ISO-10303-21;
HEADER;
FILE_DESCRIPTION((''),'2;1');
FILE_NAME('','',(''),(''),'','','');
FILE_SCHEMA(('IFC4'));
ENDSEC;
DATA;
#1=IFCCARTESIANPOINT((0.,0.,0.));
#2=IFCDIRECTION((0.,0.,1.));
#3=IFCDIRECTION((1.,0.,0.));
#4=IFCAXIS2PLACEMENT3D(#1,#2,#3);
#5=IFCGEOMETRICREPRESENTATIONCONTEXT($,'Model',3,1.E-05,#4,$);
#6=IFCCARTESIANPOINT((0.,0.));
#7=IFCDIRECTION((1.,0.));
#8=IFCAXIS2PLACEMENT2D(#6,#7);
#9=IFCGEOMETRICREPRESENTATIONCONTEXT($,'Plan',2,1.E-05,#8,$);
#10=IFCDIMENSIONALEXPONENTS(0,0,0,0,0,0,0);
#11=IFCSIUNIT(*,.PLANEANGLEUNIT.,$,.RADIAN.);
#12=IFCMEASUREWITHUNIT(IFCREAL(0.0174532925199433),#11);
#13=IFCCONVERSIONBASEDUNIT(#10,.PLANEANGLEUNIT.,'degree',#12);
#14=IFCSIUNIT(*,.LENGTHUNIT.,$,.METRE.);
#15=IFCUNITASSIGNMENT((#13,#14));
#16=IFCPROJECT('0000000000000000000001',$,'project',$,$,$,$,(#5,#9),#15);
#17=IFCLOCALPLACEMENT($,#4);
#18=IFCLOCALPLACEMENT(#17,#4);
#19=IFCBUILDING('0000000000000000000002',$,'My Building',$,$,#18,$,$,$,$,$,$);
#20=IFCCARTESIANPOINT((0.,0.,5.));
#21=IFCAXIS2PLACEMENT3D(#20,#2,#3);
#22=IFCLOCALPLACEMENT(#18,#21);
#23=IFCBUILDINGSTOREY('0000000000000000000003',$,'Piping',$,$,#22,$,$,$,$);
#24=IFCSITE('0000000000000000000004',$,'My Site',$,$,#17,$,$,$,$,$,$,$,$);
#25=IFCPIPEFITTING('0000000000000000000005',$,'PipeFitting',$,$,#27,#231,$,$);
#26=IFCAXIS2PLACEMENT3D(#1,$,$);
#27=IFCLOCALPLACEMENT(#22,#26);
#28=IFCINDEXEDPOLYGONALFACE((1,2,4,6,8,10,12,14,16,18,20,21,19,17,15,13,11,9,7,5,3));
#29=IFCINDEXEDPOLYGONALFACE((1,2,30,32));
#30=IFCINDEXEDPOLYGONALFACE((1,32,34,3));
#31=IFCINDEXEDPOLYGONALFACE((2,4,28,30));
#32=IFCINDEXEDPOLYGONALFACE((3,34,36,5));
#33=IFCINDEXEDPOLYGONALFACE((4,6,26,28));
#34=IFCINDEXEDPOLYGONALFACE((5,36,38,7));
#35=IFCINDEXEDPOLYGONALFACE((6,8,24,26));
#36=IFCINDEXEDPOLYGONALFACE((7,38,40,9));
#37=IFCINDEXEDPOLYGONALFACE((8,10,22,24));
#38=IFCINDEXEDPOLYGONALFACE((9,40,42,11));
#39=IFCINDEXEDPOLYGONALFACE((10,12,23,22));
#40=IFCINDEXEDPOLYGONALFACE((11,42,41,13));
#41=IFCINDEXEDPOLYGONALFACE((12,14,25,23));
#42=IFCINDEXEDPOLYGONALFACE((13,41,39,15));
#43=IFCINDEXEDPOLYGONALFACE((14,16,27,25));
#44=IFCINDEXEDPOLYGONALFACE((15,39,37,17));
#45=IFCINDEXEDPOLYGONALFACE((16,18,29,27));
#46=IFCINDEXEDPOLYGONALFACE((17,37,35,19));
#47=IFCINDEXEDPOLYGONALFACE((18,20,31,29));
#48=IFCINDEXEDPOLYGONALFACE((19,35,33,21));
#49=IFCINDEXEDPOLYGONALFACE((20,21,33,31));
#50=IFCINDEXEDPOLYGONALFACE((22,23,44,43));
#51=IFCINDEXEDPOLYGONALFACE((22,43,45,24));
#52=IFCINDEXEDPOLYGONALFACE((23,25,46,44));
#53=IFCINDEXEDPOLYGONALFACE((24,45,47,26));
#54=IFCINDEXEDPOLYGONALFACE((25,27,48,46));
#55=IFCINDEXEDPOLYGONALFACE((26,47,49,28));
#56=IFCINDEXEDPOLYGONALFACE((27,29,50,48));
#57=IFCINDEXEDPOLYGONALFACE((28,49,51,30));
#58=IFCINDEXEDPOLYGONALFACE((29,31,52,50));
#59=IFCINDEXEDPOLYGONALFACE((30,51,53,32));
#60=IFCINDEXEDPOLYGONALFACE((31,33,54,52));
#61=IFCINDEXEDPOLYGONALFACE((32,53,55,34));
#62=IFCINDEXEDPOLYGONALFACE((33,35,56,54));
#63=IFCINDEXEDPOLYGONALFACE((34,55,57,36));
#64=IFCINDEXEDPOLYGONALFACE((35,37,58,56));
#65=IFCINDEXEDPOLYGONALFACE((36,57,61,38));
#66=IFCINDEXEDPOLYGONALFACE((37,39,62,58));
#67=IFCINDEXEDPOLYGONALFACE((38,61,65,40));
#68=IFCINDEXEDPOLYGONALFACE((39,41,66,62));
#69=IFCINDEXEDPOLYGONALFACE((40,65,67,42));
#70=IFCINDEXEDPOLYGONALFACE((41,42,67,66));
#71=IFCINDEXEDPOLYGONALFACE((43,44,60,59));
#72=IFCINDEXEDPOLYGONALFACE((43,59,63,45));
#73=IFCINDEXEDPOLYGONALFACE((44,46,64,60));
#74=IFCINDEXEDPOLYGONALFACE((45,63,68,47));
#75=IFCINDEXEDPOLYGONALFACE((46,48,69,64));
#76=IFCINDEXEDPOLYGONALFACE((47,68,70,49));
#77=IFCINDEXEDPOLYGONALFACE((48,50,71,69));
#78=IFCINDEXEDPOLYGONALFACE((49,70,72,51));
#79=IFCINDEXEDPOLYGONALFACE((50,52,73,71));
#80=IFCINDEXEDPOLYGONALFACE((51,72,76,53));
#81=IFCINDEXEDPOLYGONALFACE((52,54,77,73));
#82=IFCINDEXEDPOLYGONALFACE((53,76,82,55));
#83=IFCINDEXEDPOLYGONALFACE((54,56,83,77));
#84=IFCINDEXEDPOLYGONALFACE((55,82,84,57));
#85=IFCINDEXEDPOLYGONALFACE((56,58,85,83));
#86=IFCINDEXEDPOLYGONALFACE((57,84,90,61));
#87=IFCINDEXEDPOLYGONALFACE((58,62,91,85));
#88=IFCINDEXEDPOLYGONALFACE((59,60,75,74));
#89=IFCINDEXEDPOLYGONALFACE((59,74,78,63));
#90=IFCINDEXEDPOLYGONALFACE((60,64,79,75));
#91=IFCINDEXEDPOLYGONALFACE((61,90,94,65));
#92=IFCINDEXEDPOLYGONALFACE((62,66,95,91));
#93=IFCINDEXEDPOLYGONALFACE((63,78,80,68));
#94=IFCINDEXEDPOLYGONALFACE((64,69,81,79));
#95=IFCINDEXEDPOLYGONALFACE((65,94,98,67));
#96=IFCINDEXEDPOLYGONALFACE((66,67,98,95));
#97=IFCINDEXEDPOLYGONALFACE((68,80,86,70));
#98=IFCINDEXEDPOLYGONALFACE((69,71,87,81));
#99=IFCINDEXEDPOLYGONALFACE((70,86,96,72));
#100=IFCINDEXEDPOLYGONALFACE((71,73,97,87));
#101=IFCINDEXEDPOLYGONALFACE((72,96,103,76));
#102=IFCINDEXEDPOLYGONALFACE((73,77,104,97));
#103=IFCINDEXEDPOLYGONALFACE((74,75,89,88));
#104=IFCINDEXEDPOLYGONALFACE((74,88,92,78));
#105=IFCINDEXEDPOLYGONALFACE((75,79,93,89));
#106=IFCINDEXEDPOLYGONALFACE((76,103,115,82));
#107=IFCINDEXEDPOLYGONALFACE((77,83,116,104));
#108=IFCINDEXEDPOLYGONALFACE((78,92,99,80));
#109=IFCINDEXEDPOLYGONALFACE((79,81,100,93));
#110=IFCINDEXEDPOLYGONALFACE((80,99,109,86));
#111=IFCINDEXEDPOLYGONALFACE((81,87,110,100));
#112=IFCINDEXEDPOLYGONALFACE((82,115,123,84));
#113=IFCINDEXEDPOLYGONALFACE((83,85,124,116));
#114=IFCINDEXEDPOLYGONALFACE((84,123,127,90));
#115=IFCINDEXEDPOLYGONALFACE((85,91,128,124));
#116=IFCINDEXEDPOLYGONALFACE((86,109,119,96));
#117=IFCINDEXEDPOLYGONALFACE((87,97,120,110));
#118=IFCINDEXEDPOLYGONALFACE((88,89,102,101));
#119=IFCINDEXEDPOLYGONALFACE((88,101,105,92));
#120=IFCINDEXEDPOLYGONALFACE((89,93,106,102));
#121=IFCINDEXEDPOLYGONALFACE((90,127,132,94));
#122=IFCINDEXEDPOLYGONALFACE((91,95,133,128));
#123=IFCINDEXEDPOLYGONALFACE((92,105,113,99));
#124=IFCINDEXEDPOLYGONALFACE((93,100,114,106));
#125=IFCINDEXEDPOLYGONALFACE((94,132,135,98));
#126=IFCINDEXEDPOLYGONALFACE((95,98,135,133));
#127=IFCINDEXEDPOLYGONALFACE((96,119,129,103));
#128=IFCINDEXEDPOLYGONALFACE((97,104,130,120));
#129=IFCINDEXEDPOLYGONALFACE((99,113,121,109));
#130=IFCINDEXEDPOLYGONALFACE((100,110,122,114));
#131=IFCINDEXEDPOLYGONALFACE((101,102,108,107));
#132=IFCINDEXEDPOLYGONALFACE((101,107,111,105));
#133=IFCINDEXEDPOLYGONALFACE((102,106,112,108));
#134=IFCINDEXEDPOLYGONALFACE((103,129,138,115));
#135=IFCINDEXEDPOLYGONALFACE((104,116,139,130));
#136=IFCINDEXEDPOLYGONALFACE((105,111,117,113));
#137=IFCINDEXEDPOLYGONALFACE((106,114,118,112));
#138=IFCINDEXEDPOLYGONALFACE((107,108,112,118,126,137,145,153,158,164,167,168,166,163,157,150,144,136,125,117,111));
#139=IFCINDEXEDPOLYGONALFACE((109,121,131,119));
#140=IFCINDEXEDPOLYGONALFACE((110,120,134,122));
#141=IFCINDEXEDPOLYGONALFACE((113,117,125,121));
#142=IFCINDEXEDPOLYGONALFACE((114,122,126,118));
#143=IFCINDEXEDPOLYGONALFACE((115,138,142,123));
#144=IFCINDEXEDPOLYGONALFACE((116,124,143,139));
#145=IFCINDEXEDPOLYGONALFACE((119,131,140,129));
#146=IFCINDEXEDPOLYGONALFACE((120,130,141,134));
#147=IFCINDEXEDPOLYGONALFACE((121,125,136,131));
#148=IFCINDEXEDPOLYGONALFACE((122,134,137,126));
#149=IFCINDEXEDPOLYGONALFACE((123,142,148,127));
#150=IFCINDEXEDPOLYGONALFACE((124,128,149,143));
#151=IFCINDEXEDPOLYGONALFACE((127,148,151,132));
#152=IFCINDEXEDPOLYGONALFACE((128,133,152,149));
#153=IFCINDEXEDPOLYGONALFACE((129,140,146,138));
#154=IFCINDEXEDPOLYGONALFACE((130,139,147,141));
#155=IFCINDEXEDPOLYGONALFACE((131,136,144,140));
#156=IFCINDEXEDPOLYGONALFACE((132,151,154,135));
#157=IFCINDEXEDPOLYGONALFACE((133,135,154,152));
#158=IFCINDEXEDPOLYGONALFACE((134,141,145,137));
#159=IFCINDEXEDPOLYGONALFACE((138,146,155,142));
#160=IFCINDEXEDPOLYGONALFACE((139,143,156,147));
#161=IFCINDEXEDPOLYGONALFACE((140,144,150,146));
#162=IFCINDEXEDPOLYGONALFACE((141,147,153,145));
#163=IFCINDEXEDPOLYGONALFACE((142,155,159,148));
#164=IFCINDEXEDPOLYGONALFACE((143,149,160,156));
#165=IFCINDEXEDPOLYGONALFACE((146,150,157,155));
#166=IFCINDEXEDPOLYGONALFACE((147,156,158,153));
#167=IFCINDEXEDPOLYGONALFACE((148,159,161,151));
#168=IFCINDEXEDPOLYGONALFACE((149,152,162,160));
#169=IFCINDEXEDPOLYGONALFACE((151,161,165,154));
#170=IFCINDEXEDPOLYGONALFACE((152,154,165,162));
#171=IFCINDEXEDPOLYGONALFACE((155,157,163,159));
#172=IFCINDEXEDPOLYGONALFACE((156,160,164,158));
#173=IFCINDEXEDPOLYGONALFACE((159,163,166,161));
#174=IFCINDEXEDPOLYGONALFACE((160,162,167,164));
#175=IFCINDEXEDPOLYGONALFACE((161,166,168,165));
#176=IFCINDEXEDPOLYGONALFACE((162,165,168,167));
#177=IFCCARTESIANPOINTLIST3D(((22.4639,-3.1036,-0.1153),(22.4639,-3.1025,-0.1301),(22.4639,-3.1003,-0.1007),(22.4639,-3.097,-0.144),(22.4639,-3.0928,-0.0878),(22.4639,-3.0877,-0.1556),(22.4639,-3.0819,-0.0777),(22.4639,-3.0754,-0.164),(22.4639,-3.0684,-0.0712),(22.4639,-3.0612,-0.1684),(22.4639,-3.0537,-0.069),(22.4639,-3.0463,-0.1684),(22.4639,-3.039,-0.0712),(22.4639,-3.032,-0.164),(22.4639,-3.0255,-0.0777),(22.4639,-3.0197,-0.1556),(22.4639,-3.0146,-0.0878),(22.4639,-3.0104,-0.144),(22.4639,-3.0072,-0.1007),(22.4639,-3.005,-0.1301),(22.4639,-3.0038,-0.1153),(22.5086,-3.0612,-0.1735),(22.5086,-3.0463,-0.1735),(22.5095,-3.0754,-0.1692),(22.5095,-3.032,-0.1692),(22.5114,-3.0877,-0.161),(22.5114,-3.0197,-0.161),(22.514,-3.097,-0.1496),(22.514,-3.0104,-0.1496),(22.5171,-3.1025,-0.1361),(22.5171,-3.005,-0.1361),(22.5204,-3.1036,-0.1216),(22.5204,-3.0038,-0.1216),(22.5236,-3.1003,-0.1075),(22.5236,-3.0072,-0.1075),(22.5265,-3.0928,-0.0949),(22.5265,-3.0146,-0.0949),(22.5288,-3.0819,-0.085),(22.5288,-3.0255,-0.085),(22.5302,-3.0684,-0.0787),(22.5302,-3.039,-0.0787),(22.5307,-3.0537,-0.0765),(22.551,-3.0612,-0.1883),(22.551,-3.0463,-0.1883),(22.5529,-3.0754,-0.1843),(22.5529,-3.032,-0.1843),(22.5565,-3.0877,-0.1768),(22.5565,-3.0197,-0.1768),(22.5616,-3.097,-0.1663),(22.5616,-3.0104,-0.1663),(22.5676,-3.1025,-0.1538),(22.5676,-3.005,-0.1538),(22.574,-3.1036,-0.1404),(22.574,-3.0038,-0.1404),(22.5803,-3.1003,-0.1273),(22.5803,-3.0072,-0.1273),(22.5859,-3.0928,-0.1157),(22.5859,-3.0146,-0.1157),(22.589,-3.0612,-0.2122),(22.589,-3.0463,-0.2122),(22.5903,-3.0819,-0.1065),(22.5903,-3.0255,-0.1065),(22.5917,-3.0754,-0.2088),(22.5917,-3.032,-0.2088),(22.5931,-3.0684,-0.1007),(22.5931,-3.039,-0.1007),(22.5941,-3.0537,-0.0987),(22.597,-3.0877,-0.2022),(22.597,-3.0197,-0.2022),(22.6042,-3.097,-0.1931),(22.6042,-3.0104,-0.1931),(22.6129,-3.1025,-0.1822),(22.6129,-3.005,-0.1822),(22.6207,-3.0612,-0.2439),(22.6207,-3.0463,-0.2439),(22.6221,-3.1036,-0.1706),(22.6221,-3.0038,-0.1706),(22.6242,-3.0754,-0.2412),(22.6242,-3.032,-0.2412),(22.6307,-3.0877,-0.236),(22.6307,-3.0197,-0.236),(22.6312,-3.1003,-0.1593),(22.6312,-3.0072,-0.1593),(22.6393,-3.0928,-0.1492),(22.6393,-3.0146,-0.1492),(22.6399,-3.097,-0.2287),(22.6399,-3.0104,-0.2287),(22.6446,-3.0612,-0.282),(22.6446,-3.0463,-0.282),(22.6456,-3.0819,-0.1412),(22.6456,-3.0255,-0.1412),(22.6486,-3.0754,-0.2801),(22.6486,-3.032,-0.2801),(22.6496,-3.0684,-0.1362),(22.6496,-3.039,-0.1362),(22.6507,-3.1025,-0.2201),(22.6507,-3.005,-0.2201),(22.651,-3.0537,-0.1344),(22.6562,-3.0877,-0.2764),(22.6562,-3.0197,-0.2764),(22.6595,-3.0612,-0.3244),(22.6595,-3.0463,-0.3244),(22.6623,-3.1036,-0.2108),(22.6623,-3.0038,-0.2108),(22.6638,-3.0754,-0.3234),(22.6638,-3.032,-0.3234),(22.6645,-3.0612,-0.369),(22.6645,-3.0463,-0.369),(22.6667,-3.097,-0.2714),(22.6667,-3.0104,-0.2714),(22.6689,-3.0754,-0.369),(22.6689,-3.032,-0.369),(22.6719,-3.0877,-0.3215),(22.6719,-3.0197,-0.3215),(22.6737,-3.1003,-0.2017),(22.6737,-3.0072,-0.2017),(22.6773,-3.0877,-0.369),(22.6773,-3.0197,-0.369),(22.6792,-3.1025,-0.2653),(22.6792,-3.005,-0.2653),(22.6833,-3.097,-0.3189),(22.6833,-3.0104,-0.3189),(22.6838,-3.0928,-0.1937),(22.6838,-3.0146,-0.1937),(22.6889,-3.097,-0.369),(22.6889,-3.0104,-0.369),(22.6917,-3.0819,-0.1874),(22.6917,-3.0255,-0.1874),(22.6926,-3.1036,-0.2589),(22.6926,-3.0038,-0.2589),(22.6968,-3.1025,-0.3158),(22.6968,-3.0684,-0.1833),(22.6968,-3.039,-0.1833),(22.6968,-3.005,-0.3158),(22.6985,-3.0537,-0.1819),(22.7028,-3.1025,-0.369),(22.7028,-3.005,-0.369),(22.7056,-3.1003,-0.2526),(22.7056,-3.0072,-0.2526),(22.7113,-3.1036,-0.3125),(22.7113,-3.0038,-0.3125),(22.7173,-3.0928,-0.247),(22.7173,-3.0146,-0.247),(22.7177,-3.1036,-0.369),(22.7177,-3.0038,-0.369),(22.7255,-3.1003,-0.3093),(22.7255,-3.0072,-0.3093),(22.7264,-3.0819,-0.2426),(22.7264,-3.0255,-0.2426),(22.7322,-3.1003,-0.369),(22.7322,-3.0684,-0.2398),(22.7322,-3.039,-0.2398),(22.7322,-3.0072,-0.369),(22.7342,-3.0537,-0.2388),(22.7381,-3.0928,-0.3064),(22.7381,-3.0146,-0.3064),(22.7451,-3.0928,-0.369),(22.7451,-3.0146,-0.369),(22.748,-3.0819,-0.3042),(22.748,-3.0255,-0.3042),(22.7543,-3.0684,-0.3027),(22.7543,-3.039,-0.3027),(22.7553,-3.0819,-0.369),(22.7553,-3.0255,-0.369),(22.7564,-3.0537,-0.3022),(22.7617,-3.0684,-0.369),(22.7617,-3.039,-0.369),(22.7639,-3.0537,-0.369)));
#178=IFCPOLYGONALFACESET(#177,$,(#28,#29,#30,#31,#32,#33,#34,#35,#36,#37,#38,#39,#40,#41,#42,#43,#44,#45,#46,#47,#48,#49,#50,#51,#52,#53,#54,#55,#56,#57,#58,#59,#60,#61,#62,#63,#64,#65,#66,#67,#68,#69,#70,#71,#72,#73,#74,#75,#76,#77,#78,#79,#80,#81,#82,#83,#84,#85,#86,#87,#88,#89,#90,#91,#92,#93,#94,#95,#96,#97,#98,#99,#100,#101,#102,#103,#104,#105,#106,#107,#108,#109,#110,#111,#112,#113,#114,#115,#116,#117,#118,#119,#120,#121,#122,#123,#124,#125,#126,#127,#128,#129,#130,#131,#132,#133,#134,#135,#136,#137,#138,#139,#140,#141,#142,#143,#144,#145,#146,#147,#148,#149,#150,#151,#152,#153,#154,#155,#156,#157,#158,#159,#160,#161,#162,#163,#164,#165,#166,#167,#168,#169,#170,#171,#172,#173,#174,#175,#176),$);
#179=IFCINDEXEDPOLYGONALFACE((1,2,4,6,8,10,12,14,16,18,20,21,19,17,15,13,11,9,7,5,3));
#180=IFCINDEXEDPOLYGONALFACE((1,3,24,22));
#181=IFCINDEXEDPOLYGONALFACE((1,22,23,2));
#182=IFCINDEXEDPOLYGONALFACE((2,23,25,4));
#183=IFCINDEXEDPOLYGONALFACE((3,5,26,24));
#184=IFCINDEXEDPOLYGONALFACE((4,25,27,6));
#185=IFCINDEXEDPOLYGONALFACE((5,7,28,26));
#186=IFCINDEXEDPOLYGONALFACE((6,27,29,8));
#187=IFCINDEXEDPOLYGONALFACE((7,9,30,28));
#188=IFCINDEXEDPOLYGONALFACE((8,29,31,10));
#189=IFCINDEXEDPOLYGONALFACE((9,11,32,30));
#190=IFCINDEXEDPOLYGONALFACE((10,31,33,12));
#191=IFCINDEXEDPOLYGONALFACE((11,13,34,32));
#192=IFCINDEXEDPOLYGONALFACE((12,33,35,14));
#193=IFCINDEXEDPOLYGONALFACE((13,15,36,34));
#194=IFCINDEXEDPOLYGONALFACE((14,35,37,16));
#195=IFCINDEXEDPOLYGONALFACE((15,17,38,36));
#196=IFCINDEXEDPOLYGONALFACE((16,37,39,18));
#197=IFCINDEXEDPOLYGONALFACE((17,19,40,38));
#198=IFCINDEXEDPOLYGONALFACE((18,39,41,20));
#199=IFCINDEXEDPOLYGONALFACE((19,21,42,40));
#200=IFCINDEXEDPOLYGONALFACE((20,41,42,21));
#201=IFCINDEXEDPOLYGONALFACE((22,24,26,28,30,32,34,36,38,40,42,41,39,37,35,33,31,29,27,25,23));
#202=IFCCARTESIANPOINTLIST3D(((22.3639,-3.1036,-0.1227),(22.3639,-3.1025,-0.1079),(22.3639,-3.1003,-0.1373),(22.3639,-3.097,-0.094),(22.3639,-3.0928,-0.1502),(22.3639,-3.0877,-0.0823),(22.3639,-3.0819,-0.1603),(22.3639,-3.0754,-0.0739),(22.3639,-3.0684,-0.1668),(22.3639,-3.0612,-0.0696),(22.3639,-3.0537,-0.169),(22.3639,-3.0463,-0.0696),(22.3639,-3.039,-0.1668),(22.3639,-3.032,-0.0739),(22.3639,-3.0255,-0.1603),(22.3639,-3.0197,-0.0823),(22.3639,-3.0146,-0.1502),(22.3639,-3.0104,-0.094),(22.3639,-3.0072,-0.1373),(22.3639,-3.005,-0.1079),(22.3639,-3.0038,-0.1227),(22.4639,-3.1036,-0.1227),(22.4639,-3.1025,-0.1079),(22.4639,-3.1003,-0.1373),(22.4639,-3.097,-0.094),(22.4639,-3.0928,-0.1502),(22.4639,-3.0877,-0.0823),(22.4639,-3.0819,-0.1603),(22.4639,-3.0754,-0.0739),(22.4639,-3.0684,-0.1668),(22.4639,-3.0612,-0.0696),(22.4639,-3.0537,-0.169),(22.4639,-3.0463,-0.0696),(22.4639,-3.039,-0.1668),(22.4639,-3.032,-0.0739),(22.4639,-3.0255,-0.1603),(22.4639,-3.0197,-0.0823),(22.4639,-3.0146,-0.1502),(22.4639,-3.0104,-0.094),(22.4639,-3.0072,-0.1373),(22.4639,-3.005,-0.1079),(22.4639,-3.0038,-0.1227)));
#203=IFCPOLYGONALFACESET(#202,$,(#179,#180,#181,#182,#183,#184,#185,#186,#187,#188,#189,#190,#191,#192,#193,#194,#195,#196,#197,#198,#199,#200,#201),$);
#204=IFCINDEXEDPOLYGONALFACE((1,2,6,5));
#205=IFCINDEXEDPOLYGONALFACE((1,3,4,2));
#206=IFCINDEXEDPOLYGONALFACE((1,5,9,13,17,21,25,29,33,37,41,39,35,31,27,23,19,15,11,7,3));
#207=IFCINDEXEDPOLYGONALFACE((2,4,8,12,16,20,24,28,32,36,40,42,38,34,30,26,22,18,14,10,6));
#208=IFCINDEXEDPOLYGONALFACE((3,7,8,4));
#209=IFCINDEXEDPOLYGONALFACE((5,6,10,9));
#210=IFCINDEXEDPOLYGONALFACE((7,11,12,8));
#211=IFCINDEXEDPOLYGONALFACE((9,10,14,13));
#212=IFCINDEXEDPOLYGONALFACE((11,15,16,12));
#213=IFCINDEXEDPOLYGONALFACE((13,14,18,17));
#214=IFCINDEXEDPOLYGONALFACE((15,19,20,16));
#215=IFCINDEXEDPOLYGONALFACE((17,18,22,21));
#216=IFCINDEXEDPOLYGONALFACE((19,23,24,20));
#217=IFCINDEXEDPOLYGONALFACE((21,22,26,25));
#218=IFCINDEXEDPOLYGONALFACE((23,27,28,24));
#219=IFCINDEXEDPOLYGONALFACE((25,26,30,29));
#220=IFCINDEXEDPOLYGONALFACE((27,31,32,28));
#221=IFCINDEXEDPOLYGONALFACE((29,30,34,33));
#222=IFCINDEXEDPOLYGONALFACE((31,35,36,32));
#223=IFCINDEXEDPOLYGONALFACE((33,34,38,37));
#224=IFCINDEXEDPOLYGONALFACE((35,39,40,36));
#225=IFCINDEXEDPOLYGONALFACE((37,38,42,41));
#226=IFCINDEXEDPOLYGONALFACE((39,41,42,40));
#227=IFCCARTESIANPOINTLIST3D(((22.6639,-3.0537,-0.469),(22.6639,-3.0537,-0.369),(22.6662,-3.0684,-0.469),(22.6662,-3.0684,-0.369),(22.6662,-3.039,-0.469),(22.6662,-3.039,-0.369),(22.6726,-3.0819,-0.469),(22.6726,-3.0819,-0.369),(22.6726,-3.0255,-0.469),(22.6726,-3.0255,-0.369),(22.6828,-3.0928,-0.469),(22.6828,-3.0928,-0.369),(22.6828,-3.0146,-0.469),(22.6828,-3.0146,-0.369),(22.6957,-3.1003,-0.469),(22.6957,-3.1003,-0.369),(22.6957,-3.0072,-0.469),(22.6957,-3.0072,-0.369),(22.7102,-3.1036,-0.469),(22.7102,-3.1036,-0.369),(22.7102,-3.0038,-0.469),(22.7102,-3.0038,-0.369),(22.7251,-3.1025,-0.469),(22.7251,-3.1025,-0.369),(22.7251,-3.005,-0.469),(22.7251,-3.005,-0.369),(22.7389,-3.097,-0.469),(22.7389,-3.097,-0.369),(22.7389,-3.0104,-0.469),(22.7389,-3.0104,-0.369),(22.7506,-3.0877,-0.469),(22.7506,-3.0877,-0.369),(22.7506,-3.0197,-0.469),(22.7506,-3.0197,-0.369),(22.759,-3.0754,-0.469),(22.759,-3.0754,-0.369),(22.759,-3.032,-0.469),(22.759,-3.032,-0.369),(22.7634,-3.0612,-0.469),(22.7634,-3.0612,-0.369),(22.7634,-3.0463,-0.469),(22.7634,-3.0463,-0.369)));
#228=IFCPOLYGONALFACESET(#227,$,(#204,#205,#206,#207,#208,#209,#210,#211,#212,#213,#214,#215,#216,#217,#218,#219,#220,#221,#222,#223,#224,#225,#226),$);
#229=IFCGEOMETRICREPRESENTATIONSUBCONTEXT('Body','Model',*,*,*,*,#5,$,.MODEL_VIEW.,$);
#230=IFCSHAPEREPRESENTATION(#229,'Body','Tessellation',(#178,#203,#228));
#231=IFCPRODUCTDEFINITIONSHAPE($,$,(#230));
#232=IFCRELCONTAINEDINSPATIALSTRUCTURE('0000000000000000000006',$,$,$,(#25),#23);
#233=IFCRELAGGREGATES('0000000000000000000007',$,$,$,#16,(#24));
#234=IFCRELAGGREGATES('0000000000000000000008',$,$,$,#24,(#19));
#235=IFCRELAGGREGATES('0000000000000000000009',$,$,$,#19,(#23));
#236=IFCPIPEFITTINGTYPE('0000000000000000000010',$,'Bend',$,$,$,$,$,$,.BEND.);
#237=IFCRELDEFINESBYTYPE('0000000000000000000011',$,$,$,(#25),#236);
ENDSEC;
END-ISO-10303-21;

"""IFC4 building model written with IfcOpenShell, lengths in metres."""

from ifc_helpers import new_model, entity, si_unit, converted_unit, frame, origin_with_axes, origin_2d_with_axis, place, context, subcontext, project, spatial, circle, extrude, source, transform, mapped, type_object, type_shapes, element, save


model = new_model("IFC4")

# Units and contexts
model_context = context("Model", 3, precision=1e-05, world=origin_with_axes())
plan_context = context("Plan", 2, precision=1e-05, world=origin_2d_with_axis())
body_context = subcontext(model_context, "Body", "Model", "MODEL_VIEW")
ifc_project = project(units=[converted_unit("PLANEANGLEUNIT", "degree", entity("IfcReal", 0.0174532925199433), si_unit("PLANEANGLEUNIT", "RADIAN"), dimensions=[0, 0, 0, 0, 0, 0, 0]), si_unit("LENGTHUNIT", "METRE")], contexts=[model_context, plan_context])

# Site, building, storey
site_placement = place(None, origin_with_axes())
site = spatial("IfcSite", under=ifc_project, at=site_placement, Name="My Site")
building_placement = place(site_placement, origin_with_axes())
building = spatial("IfcBuilding", under=site, at=building_placement, Name="My Building")
storey_placement = place(building_placement, frame((0.0, 0.0, 5.0), z_axis=(0.0, 0.0, 1.0), x_axis=(1.0, 0.0, 0.0)))
storey = spatial("IfcBuildingStorey", under=building, at=storey_placement, Name="Piping")

# Pipe fitting
pipe_fitting_type_1 = type_object("IfcPipeFittingType", Name="Bend", PredefinedType="BEND")
shared_shape = source(origin_with_axes(), body_context, "Body", "SolidModel", [
    entity("IfcSweptDiskSolid", entity("IfcIndexedPolyCurve", entity("IfcCartesianPointList3D", [[0.0, 0.0, -0.1], [0.0732, 0.0, -0.2768], [0.25, 0.0, -0.35]]), [entity("IfcArcIndex", [1, 2, 3])]), 0.05),
    extrude(circle(Radius=0.05), origin_with_axes(), (0.0, 0.0, -1.0), 0.1),
    extrude(circle(Radius=0.05), frame((0.25, 0.0, -0.35), z_axis=(1.0, 0.0, 0.0), x_axis=(0.0, 0.0, 1.0)), (0.0, 0.0, 1.0), 0.1),
])
type_shapes(pipe_fitting_type_1, [shared_shape])
for number, where, z_axis, x_axis, name in (
    (1, (22.3639, -3.0537, -0.119), (-1.0, -0.000001, 0.0), (0.0, 0.0, -1.0), "PipeFitting"),
):
    element("IfcPipeFitting", number, at=place(storey_placement, frame(where, z_axis=z_axis, x_axis=x_axis)), inside=storey, type_object=pipe_fitting_type_1, Name=name, context=body_context, shape_type="MappedRepresentation", body=[
        mapped(shared_shape, transform((0.0, 0.0, 0.0), x_axis=(1.0, 0.0, 0.0), y_axis=(0.0, 1.0, 0.0), z_axis=(0.0, 0.0, 1.0), scale=1.0)),
    ])

save(model, "model.ifc")
